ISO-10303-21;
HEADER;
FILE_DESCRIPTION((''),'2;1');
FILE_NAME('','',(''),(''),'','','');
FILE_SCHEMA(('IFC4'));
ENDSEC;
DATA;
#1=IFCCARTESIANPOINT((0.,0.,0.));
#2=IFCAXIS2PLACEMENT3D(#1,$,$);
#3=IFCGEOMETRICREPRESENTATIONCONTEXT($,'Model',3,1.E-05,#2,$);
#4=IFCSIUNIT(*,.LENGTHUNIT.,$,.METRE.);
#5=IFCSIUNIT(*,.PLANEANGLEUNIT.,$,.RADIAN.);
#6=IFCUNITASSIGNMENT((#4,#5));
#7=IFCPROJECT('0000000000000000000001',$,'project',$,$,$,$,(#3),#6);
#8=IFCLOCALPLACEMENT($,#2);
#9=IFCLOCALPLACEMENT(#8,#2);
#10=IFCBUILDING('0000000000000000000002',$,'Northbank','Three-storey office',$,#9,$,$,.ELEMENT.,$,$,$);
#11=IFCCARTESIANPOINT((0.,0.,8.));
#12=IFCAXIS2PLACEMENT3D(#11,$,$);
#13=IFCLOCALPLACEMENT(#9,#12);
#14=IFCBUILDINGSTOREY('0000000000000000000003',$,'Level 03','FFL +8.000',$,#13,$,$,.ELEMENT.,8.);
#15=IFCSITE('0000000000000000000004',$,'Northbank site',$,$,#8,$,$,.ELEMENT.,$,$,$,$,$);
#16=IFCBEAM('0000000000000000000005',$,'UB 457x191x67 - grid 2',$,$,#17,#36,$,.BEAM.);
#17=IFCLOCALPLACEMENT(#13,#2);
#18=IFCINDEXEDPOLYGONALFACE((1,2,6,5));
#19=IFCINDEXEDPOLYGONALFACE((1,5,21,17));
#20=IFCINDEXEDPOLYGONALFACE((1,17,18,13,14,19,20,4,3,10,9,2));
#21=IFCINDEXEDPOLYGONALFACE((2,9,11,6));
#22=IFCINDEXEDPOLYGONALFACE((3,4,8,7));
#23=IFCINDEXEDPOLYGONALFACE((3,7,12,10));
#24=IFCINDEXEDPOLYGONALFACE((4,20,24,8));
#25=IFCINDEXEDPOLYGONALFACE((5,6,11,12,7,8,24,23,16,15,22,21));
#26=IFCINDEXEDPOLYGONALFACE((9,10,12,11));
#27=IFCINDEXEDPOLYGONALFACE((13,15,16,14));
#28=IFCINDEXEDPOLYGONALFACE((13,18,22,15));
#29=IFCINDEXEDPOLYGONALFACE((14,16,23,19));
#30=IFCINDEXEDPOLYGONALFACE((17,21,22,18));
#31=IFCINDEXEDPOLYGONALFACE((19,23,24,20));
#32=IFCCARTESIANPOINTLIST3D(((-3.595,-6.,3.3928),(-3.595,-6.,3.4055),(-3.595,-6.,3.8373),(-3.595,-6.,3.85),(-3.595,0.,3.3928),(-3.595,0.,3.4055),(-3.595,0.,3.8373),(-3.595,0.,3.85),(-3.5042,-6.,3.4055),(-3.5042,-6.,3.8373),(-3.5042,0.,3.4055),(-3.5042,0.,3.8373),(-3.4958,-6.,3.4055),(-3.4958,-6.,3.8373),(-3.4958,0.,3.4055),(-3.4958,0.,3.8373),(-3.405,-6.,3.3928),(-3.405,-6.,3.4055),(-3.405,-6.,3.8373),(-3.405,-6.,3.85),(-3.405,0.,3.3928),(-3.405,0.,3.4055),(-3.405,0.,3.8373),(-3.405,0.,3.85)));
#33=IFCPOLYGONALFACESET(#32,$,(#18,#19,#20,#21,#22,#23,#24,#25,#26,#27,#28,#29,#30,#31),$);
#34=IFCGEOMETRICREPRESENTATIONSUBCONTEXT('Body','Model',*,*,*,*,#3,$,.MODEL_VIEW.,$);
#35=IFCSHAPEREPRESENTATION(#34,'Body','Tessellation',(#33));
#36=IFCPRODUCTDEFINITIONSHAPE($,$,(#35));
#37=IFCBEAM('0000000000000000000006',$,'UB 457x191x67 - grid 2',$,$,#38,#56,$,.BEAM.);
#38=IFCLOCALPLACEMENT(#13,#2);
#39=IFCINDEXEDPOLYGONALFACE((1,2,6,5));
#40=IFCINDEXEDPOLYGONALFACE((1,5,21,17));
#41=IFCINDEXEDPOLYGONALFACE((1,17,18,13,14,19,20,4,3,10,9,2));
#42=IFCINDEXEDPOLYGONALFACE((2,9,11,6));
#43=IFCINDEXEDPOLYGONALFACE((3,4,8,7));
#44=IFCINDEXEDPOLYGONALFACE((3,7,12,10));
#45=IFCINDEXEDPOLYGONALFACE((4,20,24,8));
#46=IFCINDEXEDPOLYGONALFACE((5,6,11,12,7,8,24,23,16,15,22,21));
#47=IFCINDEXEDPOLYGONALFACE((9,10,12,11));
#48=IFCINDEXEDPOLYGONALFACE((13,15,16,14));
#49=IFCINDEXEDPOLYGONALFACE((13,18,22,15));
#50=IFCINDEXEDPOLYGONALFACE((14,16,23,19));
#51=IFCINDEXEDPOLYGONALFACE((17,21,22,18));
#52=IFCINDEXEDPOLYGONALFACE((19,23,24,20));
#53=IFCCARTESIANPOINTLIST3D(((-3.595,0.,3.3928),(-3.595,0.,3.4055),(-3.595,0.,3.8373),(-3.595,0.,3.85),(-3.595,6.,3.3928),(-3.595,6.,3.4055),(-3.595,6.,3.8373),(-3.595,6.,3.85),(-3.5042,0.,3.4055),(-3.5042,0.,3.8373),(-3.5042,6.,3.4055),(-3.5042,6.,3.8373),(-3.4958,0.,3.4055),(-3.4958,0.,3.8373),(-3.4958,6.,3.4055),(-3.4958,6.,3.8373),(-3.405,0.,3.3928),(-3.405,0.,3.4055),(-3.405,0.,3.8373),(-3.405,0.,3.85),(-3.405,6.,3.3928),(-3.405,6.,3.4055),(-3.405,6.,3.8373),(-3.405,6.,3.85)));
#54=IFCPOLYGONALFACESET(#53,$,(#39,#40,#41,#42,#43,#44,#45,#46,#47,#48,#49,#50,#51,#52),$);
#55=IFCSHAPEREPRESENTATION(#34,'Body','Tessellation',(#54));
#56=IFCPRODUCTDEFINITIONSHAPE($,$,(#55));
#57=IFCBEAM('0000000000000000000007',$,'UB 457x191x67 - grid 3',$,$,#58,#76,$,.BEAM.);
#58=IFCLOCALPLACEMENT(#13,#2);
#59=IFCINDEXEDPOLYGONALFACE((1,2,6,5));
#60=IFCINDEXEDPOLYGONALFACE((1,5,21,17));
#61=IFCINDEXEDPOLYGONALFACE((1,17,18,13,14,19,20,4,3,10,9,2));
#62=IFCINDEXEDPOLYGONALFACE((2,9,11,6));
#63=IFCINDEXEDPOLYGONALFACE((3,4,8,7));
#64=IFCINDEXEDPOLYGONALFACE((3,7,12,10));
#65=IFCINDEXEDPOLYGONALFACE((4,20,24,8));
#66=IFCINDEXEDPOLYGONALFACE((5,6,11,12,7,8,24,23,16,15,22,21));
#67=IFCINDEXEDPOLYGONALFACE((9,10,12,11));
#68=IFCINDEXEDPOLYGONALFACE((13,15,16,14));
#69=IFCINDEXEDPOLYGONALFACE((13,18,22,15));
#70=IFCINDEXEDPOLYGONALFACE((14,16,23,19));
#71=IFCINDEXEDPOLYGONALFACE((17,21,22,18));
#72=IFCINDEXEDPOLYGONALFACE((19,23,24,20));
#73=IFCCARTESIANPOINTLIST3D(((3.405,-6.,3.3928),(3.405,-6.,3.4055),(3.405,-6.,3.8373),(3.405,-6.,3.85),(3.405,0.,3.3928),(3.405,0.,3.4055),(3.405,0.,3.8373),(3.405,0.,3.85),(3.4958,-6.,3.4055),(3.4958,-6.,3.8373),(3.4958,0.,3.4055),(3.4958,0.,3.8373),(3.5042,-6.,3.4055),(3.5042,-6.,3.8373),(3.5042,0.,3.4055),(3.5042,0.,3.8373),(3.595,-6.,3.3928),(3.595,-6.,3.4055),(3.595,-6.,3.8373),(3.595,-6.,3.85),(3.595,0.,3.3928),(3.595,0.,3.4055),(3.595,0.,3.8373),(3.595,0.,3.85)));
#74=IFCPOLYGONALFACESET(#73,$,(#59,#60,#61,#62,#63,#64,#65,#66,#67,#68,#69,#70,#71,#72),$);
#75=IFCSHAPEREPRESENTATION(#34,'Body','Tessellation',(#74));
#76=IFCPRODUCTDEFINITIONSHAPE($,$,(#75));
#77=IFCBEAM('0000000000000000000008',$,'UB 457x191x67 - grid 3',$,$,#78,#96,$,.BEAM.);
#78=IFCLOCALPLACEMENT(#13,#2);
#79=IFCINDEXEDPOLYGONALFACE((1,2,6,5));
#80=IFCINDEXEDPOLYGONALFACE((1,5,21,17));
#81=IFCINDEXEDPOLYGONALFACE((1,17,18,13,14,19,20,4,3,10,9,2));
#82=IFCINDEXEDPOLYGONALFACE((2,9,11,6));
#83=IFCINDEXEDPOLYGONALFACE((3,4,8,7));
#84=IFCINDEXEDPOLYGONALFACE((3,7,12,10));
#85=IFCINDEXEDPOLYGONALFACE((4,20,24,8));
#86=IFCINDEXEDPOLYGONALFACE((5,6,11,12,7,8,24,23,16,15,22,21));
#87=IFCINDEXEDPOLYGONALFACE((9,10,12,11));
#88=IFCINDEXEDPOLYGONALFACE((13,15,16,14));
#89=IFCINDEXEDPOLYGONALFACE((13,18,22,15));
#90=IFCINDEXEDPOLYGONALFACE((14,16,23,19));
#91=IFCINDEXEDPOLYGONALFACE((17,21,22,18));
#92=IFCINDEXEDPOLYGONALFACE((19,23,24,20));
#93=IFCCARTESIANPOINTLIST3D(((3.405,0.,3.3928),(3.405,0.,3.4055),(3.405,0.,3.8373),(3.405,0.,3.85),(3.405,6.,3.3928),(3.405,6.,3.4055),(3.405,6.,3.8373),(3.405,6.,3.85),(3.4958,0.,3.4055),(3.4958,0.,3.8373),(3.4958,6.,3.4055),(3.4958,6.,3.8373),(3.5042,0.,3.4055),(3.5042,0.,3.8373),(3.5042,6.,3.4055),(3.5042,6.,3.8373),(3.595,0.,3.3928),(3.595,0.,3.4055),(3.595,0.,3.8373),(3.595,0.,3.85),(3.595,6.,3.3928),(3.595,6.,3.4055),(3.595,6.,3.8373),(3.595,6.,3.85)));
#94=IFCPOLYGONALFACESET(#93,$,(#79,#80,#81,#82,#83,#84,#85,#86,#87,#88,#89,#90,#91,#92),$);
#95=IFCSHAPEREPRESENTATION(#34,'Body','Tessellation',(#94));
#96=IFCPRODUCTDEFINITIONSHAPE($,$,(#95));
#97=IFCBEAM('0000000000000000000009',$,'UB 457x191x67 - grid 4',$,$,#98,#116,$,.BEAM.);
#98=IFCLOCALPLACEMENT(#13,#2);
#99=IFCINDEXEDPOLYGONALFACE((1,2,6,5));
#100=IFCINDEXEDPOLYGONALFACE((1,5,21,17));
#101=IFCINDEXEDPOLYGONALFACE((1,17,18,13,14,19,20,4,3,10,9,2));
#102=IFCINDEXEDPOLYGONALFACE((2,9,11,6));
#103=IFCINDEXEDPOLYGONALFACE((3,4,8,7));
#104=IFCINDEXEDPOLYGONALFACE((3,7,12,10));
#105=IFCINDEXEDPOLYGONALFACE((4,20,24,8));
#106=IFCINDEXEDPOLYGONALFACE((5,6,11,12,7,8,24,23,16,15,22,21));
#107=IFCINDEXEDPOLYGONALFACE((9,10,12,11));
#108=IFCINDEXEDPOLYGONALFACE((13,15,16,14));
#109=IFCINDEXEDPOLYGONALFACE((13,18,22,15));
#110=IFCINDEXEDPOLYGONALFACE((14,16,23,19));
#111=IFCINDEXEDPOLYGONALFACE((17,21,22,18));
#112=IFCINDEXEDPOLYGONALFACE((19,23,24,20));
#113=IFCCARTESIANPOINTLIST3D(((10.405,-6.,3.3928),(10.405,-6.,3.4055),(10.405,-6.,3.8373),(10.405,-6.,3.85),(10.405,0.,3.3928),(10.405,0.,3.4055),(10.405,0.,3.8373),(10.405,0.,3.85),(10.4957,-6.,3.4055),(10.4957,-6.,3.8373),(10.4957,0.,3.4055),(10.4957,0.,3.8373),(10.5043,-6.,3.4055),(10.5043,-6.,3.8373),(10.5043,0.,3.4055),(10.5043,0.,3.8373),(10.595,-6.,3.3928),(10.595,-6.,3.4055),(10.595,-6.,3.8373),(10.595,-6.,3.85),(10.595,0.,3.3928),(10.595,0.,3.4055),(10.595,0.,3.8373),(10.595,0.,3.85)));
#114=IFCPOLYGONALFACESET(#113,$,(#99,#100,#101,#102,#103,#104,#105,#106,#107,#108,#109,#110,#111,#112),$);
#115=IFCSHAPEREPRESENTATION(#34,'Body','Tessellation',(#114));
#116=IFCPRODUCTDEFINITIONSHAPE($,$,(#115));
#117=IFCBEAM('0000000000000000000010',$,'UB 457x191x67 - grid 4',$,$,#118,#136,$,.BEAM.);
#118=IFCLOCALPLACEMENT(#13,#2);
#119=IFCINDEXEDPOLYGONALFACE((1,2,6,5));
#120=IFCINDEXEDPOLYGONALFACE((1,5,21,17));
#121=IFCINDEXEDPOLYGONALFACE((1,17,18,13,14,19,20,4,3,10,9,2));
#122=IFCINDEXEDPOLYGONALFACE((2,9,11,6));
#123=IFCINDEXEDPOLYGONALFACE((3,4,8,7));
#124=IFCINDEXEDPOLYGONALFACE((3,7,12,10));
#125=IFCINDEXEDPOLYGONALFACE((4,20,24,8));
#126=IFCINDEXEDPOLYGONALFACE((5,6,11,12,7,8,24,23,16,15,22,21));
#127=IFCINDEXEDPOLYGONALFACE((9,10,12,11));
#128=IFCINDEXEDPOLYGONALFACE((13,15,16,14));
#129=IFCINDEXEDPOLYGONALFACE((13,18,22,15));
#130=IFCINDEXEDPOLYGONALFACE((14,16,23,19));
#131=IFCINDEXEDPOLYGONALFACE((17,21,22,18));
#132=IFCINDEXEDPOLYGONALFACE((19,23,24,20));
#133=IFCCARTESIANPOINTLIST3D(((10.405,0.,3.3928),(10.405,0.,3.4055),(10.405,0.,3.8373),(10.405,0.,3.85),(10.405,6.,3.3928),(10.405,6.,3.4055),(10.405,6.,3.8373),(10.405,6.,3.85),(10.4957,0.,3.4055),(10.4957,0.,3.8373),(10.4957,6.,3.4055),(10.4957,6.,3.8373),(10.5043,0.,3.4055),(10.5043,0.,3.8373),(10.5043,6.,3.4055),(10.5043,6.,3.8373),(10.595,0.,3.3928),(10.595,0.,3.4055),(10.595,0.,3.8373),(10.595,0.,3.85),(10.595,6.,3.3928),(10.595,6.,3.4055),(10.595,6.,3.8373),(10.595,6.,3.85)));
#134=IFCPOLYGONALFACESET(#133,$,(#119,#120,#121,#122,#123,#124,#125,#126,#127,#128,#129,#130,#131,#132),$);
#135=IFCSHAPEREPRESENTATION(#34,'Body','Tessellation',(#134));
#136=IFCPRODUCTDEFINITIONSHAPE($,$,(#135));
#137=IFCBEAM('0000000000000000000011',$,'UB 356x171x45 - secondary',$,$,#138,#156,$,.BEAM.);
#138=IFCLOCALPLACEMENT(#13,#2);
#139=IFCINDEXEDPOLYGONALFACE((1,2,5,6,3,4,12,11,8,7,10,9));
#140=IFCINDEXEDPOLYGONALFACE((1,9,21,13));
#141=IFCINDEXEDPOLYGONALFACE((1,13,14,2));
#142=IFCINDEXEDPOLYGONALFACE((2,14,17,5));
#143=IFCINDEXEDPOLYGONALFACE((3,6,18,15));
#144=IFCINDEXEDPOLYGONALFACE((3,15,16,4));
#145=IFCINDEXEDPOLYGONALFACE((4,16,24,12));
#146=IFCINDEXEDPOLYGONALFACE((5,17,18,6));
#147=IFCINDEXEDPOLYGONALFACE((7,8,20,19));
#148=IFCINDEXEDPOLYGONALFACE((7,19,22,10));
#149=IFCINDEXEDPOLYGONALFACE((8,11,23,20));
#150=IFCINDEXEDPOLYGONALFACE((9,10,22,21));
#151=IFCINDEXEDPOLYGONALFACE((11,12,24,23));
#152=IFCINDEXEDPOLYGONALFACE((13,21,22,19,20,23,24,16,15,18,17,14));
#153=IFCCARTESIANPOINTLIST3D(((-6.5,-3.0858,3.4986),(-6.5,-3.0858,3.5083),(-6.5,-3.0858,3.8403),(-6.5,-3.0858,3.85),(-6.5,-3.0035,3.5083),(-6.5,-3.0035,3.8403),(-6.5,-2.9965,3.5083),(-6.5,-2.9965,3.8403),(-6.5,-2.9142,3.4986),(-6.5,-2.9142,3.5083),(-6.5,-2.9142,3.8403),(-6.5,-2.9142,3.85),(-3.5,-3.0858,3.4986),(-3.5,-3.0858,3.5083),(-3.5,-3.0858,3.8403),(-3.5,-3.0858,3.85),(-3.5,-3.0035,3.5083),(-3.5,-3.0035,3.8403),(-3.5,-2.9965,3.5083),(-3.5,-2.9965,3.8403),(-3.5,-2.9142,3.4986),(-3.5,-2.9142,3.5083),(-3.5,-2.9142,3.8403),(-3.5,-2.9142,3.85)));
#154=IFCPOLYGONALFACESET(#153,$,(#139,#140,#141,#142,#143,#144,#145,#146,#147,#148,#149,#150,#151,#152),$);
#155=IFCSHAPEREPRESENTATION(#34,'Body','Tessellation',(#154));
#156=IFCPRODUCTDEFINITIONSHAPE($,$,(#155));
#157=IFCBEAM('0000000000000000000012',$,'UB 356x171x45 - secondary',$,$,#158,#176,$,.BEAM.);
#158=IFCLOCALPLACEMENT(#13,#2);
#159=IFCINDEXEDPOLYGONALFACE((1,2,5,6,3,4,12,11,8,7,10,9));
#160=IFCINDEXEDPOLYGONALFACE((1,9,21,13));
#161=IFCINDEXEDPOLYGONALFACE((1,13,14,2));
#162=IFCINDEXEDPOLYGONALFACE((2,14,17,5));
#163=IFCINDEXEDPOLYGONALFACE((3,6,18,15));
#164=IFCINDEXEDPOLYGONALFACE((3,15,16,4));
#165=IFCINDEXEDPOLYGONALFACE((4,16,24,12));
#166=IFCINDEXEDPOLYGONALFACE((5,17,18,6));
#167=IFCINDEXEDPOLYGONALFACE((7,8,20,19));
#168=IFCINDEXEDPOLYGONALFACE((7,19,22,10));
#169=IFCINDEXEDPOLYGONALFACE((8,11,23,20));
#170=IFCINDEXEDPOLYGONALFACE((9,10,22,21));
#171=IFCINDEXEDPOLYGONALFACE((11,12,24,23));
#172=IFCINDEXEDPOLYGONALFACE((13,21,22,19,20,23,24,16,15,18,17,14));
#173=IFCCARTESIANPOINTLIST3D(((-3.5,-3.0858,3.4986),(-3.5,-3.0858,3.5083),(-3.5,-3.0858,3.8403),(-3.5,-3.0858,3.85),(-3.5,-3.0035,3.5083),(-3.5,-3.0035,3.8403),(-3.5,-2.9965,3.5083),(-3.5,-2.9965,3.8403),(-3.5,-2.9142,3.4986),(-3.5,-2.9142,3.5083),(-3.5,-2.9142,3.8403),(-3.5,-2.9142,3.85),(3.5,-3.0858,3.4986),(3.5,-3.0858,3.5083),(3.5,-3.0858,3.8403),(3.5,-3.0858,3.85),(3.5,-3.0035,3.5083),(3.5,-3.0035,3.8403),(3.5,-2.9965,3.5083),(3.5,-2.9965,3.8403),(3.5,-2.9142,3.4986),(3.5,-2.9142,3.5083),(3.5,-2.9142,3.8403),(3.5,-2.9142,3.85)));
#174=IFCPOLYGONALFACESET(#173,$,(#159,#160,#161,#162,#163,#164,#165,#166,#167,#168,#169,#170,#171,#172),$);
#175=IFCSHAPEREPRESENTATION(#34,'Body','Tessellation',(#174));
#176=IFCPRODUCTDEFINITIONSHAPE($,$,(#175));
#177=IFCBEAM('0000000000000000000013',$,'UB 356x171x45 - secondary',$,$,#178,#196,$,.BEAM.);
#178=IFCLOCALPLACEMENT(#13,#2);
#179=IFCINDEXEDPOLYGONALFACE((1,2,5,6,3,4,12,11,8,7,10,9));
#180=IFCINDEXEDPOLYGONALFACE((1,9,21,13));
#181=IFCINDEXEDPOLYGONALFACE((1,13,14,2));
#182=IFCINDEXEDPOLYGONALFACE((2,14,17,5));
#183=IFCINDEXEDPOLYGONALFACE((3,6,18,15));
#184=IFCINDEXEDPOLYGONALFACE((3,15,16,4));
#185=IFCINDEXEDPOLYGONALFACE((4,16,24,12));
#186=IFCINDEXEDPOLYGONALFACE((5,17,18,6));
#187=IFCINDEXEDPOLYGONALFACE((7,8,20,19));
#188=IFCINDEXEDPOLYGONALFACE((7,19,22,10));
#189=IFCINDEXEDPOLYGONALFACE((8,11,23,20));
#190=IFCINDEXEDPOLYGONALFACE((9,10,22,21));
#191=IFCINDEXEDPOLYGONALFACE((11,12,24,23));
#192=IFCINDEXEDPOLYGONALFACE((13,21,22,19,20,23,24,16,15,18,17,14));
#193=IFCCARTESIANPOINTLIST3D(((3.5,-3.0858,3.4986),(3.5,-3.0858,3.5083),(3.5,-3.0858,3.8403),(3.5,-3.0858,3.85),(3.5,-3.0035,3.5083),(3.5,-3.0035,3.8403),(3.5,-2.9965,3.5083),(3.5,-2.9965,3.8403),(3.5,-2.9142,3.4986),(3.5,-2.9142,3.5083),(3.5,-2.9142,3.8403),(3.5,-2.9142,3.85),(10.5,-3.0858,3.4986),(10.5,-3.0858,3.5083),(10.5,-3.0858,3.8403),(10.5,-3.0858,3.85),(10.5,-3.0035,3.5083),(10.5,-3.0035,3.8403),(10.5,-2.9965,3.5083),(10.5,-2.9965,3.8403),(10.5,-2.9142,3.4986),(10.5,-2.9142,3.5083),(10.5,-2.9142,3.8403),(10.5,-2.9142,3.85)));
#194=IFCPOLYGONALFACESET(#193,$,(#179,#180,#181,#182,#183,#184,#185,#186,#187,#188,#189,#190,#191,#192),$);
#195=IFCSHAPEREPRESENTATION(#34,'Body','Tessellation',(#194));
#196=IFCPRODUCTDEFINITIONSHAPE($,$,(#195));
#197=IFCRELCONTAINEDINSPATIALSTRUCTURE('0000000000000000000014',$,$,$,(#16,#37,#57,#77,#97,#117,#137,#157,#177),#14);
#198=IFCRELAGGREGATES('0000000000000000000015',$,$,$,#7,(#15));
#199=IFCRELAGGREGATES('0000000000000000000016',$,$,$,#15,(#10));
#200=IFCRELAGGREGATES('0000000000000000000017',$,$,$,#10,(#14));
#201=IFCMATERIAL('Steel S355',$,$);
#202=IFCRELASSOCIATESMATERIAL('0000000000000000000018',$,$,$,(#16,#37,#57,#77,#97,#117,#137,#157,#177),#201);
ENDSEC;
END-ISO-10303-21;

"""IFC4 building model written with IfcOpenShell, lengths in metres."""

from ifc_helpers import new_model, si_unit, frame, origin, place, context, subcontext, project, spatial, i_section, extrude, material, element, save


model = new_model("IFC4")

# Units and contexts
model_context = context("Model", 3, precision=1e-05, world=origin())
body_context = subcontext(model_context, "Body", "Model", "MODEL_VIEW")
ifc_project = project(units=[si_unit("LENGTHUNIT", "METRE"), si_unit("PLANEANGLEUNIT", "RADIAN")], contexts=[model_context])

# Site, building, storey
site_placement = place(None, origin())
site = spatial("IfcSite", under=ifc_project, at=site_placement, Name="Northbank site", CompositionType="ELEMENT")
building_placement = place(site_placement, origin())
building = spatial("IfcBuilding", under=site, at=building_placement, Name="Northbank", Description="Three-storey office", CompositionType="ELEMENT")
storey_placement = place(building_placement, frame((0.0, 0.0, 8.0)))
storey = spatial("IfcBuildingStorey", under=building, at=storey_placement, Name="Level 03", Description="FFL +8.000", CompositionType="ELEMENT", Elevation=8.0)

# Beams
ifc_material_1 = material(Name="Steel S355")
beam_1_placement = place(storey_placement, frame((0.0, 0.0, -8.0)))
element("IfcBeam", 1, at=beam_1_placement, inside=storey, material=ifc_material_1, Name="UB 457x191x67 - grid 2", PredefinedType="BEAM", context=body_context, shape_type="SweptSolid", body=[
    extrude(i_section(OverallWidth=0.1899, OverallDepth=0.4572, WebThickness=0.0085, FlangeThickness=0.0127), frame((-3.5, -6.0, 11.6214), z_axis=(0.0, 1.0, 0.0), x_axis=(-1.0, 0.0, 0.0)), (0.0, 0.0, 1.0), 6.0),
])
beam_2_placement = place(storey_placement, frame((0.0, 0.0, -8.0)))
element("IfcBeam", 2, at=beam_2_placement, inside=storey, material=ifc_material_1, Name="UB 457x191x67 - grid 2", PredefinedType="BEAM", context=body_context, shape_type="SweptSolid", body=[
    extrude(i_section(OverallWidth=0.1899, OverallDepth=0.4572, WebThickness=0.0085, FlangeThickness=0.0127), frame((-3.5, 0.0, 11.6214), z_axis=(0.0, 1.0, 0.0), x_axis=(-1.0, 0.0, 0.0)), (0.0, 0.0, 1.0), 6.0),
])
beam_3_placement = place(storey_placement, frame((0.0, 0.0, -8.0)))
element("IfcBeam", 3, at=beam_3_placement, inside=storey, material=ifc_material_1, Name="UB 457x191x67 - grid 3", PredefinedType="BEAM", context=body_context, shape_type="SweptSolid", body=[
    extrude(i_section(OverallWidth=0.1899, OverallDepth=0.4572, WebThickness=0.0085, FlangeThickness=0.0127), frame((3.5, -6.0, 11.6214), z_axis=(0.0, 1.0, 0.0), x_axis=(-1.0, 0.0, 0.0)), (0.0, 0.0, 1.0), 6.0),
])
beam_4_placement = place(storey_placement, frame((0.0, 0.0, -8.0)))
element("IfcBeam", 4, at=beam_4_placement, inside=storey, material=ifc_material_1, Name="UB 457x191x67 - grid 3", PredefinedType="BEAM", context=body_context, shape_type="SweptSolid", body=[
    extrude(i_section(OverallWidth=0.1899, OverallDepth=0.4572, WebThickness=0.0085, FlangeThickness=0.0127), frame((3.5, 0.0, 11.6214), z_axis=(0.0, 1.0, 0.0), x_axis=(-1.0, 0.0, 0.0)), (0.0, 0.0, 1.0), 6.0),
])
beam_5_placement = place(storey_placement, frame((0.0, 0.0, -8.0)))
element("IfcBeam", 5, at=beam_5_placement, inside=storey, material=ifc_material_1, Name="UB 457x191x67 - grid 4", PredefinedType="BEAM", context=body_context, shape_type="SweptSolid", body=[
    extrude(i_section(OverallWidth=0.1899, OverallDepth=0.4572, WebThickness=0.0085, FlangeThickness=0.0127), frame((10.5, -6.0, 11.6214), z_axis=(0.0, 1.0, 0.0), x_axis=(-1.0, 0.0, 0.0)), (0.0, 0.0, 1.0), 6.0),
])
beam_6_placement = place(storey_placement, frame((0.0, 0.0, -8.0)))
element("IfcBeam", 6, at=beam_6_placement, inside=storey, material=ifc_material_1, Name="UB 457x191x67 - grid 4", PredefinedType="BEAM", context=body_context, shape_type="SweptSolid", body=[
    extrude(i_section(OverallWidth=0.1899, OverallDepth=0.4572, WebThickness=0.0085, FlangeThickness=0.0127), frame((10.5, 0.0, 11.6214), z_axis=(0.0, 1.0, 0.0), x_axis=(-1.0, 0.0, 0.0)), (0.0, 0.0, 1.0), 6.0),
])
beam_7_placement = place(storey_placement, frame((0.0, 0.0, -8.0)))
element("IfcBeam", 7, at=beam_7_placement, inside=storey, material=ifc_material_1, Name="UB 356x171x45 - secondary", PredefinedType="BEAM", context=body_context, shape_type="SweptSolid", body=[
    extrude(i_section(OverallWidth=0.1715, OverallDepth=0.3514, WebThickness=0.007, FlangeThickness=0.0097), frame((-6.5, -3.0, 11.6743), z_axis=(1.0, 0.0, 0.0), x_axis=(0.0, 1.0, 0.0)), (0.0, 0.0, 1.0), 3.0),
])
beam_8_placement = place(storey_placement, frame((0.0, 0.0, -8.0)))
element("IfcBeam", 8, at=beam_8_placement, inside=storey, material=ifc_material_1, Name="UB 356x171x45 - secondary", PredefinedType="BEAM", context=body_context, shape_type="SweptSolid", body=[
    extrude(i_section(OverallWidth=0.1715, OverallDepth=0.3514, WebThickness=0.007, FlangeThickness=0.0097), frame((-3.5, -3.0, 11.6743), z_axis=(1.0, 0.0, 0.0), x_axis=(0.0, 1.0, 0.0)), (0.0, 0.0, 1.0), 7.0),
])
beam_9_placement = place(storey_placement, frame((0.0, 0.0, -8.0)))
element("IfcBeam", 9, at=beam_9_placement, inside=storey, material=ifc_material_1, Name="UB 356x171x45 - secondary", PredefinedType="BEAM", context=body_context, shape_type="SweptSolid", body=[
    extrude(i_section(OverallWidth=0.1715, OverallDepth=0.3514, WebThickness=0.007, FlangeThickness=0.0097), frame((3.5, -3.0, 11.6743), z_axis=(1.0, 0.0, 0.0), x_axis=(0.0, 1.0, 0.0)), (0.0, 0.0, 1.0), 7.0),
])

save(model, "model.ifc")
